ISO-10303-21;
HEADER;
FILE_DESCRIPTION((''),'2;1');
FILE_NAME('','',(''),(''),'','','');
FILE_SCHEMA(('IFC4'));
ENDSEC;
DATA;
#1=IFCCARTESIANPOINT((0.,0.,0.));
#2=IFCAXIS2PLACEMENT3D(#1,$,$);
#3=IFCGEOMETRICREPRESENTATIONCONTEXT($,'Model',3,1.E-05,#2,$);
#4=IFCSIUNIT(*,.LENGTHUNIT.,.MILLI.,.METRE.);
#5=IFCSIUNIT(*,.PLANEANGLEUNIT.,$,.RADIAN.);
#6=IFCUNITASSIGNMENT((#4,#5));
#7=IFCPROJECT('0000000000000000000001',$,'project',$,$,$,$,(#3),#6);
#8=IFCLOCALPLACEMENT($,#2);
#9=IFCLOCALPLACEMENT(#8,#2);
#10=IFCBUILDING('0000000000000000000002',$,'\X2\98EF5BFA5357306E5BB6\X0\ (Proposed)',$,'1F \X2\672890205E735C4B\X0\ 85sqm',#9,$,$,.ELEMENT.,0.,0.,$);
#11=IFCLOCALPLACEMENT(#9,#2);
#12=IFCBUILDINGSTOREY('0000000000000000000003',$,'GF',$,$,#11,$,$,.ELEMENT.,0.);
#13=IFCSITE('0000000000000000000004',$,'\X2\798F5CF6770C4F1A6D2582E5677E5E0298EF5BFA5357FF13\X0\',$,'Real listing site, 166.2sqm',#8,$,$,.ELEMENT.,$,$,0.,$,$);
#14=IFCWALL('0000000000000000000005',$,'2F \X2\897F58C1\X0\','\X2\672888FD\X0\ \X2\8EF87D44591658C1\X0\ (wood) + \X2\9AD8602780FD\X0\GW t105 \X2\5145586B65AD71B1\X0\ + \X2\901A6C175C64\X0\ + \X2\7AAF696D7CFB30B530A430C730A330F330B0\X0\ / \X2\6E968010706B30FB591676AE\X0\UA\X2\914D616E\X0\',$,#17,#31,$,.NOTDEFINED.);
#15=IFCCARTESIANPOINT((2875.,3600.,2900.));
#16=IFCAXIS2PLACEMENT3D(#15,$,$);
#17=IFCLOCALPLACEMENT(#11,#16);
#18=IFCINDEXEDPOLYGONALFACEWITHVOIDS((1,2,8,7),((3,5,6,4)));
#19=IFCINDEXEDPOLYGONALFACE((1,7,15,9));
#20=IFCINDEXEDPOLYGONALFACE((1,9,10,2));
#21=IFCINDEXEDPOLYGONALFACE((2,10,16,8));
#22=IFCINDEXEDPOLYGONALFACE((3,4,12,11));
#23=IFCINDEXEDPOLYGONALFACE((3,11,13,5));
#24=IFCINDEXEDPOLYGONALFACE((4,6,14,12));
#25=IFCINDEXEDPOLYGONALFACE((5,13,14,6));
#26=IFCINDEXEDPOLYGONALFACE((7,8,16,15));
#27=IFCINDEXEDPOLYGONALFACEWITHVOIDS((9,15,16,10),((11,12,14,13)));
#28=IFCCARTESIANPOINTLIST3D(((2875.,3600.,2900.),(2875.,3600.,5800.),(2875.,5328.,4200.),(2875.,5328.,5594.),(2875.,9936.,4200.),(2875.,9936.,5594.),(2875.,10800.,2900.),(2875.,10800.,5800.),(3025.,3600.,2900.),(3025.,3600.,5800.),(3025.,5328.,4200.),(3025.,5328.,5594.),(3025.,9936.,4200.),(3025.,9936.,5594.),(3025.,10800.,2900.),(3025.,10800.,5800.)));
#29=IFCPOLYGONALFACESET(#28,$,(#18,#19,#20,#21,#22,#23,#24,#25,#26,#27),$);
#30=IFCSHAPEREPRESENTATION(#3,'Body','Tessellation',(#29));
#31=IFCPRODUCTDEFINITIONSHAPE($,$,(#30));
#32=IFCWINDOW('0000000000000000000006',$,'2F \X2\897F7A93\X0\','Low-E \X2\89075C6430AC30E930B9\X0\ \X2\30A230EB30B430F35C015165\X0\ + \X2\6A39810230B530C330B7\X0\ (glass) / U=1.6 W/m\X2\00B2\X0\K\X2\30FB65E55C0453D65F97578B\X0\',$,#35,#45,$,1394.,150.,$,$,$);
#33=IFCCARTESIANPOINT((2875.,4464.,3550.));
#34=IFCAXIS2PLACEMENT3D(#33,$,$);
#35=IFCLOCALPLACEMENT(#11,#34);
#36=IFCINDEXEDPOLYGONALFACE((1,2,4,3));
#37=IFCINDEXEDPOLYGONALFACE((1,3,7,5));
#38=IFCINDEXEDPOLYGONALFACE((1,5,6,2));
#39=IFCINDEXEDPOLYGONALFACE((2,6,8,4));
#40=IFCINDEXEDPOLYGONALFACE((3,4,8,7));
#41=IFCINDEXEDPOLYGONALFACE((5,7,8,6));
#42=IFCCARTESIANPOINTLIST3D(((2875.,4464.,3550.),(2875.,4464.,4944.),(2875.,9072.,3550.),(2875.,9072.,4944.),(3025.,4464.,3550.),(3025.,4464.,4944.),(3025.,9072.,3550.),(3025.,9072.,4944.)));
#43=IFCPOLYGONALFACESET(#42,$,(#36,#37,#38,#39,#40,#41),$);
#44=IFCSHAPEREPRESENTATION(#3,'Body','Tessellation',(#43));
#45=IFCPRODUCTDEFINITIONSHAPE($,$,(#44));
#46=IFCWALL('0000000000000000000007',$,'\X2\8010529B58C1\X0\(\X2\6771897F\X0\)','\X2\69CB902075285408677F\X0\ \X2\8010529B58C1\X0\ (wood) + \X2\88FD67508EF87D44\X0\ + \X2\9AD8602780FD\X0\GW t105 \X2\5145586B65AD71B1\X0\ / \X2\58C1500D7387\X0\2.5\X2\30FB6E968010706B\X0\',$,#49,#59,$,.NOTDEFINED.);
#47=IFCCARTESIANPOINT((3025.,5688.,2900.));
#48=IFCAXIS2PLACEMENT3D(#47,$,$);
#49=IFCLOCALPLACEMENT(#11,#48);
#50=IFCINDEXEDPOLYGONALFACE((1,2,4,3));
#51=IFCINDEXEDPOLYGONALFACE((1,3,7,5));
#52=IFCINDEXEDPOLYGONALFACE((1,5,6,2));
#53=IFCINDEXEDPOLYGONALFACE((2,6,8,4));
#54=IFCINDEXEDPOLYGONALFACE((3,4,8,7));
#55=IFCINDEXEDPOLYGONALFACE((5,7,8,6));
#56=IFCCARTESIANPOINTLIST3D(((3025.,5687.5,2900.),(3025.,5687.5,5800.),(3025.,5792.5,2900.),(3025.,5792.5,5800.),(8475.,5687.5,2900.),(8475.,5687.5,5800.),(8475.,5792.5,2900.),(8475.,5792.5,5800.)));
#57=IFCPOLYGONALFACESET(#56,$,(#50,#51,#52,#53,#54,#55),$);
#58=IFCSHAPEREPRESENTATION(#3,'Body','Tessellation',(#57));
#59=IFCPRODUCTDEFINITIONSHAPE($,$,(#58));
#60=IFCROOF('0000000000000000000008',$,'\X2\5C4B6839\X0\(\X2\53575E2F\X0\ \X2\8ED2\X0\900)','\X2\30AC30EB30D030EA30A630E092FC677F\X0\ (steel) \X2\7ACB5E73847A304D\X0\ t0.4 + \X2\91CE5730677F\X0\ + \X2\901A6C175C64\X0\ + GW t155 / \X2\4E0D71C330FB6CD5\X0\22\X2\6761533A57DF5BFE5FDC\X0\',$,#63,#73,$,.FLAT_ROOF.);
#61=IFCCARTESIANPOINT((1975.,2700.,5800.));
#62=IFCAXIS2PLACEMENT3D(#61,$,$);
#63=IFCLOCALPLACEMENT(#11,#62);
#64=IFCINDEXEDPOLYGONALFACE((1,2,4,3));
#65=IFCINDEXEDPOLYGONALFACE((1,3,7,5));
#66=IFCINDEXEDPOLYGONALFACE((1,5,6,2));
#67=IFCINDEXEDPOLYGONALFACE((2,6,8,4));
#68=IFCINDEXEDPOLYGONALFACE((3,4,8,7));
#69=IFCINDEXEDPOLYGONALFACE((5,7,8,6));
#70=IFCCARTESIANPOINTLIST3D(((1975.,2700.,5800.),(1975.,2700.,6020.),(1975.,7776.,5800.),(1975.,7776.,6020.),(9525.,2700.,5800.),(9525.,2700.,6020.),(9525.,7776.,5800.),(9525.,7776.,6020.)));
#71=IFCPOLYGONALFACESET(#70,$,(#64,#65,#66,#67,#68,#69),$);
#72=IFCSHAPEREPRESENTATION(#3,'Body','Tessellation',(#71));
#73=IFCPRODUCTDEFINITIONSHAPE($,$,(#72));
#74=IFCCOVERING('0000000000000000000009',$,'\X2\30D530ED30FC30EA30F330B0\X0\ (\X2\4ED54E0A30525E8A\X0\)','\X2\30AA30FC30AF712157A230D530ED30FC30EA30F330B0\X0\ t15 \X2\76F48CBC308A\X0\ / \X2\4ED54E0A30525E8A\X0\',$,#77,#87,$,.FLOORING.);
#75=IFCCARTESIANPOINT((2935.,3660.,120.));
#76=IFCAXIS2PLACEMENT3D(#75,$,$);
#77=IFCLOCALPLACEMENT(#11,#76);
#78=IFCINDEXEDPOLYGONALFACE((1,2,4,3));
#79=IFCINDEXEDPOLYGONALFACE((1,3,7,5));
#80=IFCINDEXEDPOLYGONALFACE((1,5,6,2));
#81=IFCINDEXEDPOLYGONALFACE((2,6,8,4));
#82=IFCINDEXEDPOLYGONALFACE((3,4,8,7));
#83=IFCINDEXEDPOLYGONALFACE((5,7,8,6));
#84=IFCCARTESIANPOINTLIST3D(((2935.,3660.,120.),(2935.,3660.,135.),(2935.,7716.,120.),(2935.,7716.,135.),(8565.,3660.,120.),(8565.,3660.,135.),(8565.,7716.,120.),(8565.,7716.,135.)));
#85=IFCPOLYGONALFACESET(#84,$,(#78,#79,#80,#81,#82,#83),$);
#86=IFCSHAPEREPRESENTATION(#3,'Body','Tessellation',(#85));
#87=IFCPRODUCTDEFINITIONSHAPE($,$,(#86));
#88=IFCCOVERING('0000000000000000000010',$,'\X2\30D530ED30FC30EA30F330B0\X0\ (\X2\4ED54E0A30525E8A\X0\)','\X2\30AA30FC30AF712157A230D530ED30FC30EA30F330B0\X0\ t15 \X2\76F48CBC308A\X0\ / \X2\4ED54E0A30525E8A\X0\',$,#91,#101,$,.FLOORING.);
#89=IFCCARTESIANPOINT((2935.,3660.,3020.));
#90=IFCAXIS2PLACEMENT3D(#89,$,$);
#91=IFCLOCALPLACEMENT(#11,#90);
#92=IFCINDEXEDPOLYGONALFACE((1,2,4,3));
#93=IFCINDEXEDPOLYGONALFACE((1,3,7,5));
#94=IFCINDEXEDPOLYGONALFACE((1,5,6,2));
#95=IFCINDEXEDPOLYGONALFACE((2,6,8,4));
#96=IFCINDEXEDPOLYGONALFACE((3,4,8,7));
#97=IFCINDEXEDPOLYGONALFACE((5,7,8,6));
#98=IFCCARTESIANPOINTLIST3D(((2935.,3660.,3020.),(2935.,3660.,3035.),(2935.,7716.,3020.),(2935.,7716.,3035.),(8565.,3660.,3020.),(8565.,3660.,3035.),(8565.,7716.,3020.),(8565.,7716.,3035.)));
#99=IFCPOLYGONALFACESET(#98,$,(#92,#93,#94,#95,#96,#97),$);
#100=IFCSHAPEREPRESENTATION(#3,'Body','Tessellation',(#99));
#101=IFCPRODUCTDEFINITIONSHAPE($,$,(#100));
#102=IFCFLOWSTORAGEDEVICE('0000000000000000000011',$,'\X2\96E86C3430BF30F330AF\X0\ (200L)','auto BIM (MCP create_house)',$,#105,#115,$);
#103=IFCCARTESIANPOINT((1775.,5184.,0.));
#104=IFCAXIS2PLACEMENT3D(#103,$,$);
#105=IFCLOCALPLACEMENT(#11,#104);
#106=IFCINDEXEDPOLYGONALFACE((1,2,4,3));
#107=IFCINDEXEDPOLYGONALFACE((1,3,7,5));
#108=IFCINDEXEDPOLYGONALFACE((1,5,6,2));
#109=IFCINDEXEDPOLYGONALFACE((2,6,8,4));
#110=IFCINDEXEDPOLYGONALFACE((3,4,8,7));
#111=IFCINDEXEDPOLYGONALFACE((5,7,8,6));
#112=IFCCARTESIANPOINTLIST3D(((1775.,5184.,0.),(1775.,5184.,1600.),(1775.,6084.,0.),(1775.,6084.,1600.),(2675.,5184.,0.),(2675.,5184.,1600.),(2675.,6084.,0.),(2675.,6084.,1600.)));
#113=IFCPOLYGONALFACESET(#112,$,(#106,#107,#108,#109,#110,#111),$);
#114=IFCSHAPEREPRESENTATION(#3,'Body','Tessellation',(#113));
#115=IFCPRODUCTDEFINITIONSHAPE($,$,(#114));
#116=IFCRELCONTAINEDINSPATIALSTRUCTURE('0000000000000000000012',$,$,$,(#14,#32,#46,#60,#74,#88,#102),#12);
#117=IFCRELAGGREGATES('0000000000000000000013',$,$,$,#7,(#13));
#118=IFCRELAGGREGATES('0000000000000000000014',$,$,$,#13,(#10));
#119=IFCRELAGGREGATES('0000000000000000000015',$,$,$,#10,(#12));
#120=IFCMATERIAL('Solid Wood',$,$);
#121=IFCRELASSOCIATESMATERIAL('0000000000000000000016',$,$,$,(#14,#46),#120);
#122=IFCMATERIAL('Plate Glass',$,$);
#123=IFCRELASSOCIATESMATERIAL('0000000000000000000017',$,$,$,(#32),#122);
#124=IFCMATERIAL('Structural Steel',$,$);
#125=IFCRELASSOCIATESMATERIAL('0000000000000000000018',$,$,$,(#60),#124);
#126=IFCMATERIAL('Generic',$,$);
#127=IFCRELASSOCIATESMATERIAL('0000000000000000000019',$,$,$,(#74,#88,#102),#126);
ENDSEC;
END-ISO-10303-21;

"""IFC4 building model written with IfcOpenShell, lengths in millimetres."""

from ifc_helpers import new_model, si_unit, frame, frame_2d, origin, place, context, project, spatial, rectangle, extrude, material, element, fill, save


model = new_model("IFC4")

# Units and contexts
model_context = context("Model", 3, precision=1e-05, world=origin())
ifc_project = project(units=[si_unit("LENGTHUNIT", "METRE", prefix="MILLI"), si_unit("PLANEANGLEUNIT", "RADIAN")], contexts=[model_context])

# Site, building, storey
site_placement = place(None, origin())
site = spatial("IfcSite", under=ifc_project, at=site_placement, Name="福島県会津若松市飯寺南３", ObjectType="Real listing site, 166.2sqm", CompositionType="ELEMENT", RefElevation=0.0)
building_placement = place(site_placement, origin())
building = spatial("IfcBuilding", under=site, at=building_placement, Name="飯寺南の家 (Proposed)", ObjectType="1F 木造平屋 85sqm", CompositionType="ELEMENT", ElevationOfRefHeight=0.0, ElevationOfTerrain=0.0)
storey_placement = place(building_placement, origin())
storey = spatial("IfcBuildingStorey", under=building, at=storey_placement, Name="GF", CompositionType="ELEMENT", Elevation=0.0)

# Shared definitions
ifc_material_1 = material(Name="Solid Wood")
ifc_material_2 = material(Name="Generic")

# Shared definitions
ifc_material_3 = material(Name="Plate Glass")

# Wall, opening, window
wall_1_placement = place(storey_placement, frame((2875.0, 3600.0, 2900.0)))
wall_1 = element("IfcWall", 1, at=wall_1_placement, inside=storey, material=ifc_material_1, Name="2F 西壁", Description="木製 軸組外壁 (wood) + 高性能GW t105 充填断熱 + 通気層 + 窯業系サイディング / 準耐火・外皮UA配慮", PredefinedType="NOTDEFINED", context=model_context, shape_type="SweptSolid", body=[
    extrude(rectangle(XDim=150.0, YDim=7200.0, at=frame_2d((75.0, 3600.0))), frame((2875.0, 3600.0, 2900.0)), (0.0, 0.0, 1.0), 2900.0),
])
opening_1_placement = place(storey_placement, frame((2875.0, 4464.0, 3550.0)))
opening_1 = element("IfcOpeningElement", 2, at=opening_1_placement, cuts=wall_1, PredefinedType="NOTDEFINED", context=model_context, shape_type="SweptSolid", body=[
    extrude(rectangle(XDim=150.0, YDim=4608.0, at=frame_2d((75.0, 2304.0))), frame((2875.0, 4464.0, 3550.0)), (0.0, 0.0, 1.0), 1394.0),
])
window_1_placement = place(storey_placement, frame((2875.0, 4464.0, 3550.0)))
window_1 = element("IfcWindow", 3, at=window_1_placement, inside=storey, material=ifc_material_3, Name="2F 西窓", Description="Low-E 複層ガラス アルゴン封入 + 樹脂サッシ (glass) / U=1.6 W/m²K・日射取得型", OverallHeight=1394.0, OverallWidth=150.0, context=model_context, shape_type="SweptSolid", body=[
    extrude(rectangle(XDim=150.0, YDim=4608.0, at=frame_2d((75.0, 2304.0))), frame((2875.0, 4464.0, 3550.0)), (0.0, 0.0, 1.0), 1394.0),
])
fill(opening_1, window_1)

# Wall
wall_2_placement = place(storey_placement, frame((3025.0, 5688.0, 2900.0)))
element("IfcWall", 4, at=wall_2_placement, inside=storey, material=ifc_material_1, Name="耐力壁(東西)", Description="構造用合板 耐力壁 (wood) + 製材軸組 + 高性能GW t105 充填断熱 / 壁倍率2.5・準耐火", PredefinedType="NOTDEFINED", context=model_context, shape_type="SweptSolid", body=[
    extrude(rectangle(XDim=5450.0, YDim=105.0, at=frame_2d((2725.0, 52.0))), frame((3025.0, 5688.0, 2900.0)), (0.0, 0.0, 1.0), 2900.0),
])

# Roof
ifc_material_4 = material(Name="Structural Steel")
for number, where, name in (
    (5, (1975.0, 2700.0, 5800.0), "屋根(南帯 軒900)"),
):
    element("IfcRoof", number, at=place(storey_placement, frame(where)), inside=storey, material=ifc_material_4, Name=name, Description="ガルバリウム鋼板 (steel) 立平葺き t0.4 + 野地板 + 通気層 + GW t155 / 不燃・法22条区域対応", PredefinedType="FLAT_ROOF", context=model_context, shape_type="SweptSolid", body=[
        extrude(rectangle(XDim=7550.0, YDim=5076.0, at=frame_2d((3775.0, 2538.0))), frame((1975.0, 2700.0, 5800.0)), (0.0, 0.0, 1.0), 220.0),
    ])

# Coverings
covering_1_placement = place(storey_placement, frame((2935.0, 3660.0, 120.0)))
element("IfcCovering", 6, at=covering_1_placement, inside=storey, material=ifc_material_2, Name="フローリング (仕上げ床)", Description="オーク無垢フローリング t15 直貼り / 仕上げ床", PredefinedType="FLOORING", context=model_context, shape_type="SweptSolid", body=[
    extrude(rectangle(XDim=5630.0, YDim=4056.0, at=frame_2d((2815.0, 2028.0))), frame((2935.0, 3660.0, 120.0)), (0.0, 0.0, 1.0), 15.0),
])
covering_2_placement = place(storey_placement, frame((2935.0, 3660.0, 3020.0)))
element("IfcCovering", 7, at=covering_2_placement, inside=storey, material=ifc_material_2, Name="フローリング (仕上げ床)", Description="オーク無垢フローリング t15 直貼り / 仕上げ床", PredefinedType="FLOORING", context=model_context, shape_type="SweptSolid", body=[
    extrude(rectangle(XDim=5630.0, YDim=4056.0, at=frame_2d((2815.0, 2028.0))), frame((2935.0, 3660.0, 3020.0)), (0.0, 0.0, 1.0), 15.0),
])

# Flow storage device
flow_storage_device_placement = place(storey_placement, frame((1775.0, 5184.0, 0.0)))
element("IfcFlowStorageDevice", 8, at=flow_storage_device_placement, inside=storey, material=ifc_material_2, Name="雨水タンク (200L)", Description="auto BIM (MCP create_house)", context=model_context, shape_type="SweptSolid", body=[
    extrude(rectangle(XDim=900.0, YDim=900.0, at=frame_2d((450.0, 450.0))), frame((1775.0, 5184.0, 0.0)), (0.0, 0.0, 1.0), 1600.0),
])

save(model, "model.ifc")
